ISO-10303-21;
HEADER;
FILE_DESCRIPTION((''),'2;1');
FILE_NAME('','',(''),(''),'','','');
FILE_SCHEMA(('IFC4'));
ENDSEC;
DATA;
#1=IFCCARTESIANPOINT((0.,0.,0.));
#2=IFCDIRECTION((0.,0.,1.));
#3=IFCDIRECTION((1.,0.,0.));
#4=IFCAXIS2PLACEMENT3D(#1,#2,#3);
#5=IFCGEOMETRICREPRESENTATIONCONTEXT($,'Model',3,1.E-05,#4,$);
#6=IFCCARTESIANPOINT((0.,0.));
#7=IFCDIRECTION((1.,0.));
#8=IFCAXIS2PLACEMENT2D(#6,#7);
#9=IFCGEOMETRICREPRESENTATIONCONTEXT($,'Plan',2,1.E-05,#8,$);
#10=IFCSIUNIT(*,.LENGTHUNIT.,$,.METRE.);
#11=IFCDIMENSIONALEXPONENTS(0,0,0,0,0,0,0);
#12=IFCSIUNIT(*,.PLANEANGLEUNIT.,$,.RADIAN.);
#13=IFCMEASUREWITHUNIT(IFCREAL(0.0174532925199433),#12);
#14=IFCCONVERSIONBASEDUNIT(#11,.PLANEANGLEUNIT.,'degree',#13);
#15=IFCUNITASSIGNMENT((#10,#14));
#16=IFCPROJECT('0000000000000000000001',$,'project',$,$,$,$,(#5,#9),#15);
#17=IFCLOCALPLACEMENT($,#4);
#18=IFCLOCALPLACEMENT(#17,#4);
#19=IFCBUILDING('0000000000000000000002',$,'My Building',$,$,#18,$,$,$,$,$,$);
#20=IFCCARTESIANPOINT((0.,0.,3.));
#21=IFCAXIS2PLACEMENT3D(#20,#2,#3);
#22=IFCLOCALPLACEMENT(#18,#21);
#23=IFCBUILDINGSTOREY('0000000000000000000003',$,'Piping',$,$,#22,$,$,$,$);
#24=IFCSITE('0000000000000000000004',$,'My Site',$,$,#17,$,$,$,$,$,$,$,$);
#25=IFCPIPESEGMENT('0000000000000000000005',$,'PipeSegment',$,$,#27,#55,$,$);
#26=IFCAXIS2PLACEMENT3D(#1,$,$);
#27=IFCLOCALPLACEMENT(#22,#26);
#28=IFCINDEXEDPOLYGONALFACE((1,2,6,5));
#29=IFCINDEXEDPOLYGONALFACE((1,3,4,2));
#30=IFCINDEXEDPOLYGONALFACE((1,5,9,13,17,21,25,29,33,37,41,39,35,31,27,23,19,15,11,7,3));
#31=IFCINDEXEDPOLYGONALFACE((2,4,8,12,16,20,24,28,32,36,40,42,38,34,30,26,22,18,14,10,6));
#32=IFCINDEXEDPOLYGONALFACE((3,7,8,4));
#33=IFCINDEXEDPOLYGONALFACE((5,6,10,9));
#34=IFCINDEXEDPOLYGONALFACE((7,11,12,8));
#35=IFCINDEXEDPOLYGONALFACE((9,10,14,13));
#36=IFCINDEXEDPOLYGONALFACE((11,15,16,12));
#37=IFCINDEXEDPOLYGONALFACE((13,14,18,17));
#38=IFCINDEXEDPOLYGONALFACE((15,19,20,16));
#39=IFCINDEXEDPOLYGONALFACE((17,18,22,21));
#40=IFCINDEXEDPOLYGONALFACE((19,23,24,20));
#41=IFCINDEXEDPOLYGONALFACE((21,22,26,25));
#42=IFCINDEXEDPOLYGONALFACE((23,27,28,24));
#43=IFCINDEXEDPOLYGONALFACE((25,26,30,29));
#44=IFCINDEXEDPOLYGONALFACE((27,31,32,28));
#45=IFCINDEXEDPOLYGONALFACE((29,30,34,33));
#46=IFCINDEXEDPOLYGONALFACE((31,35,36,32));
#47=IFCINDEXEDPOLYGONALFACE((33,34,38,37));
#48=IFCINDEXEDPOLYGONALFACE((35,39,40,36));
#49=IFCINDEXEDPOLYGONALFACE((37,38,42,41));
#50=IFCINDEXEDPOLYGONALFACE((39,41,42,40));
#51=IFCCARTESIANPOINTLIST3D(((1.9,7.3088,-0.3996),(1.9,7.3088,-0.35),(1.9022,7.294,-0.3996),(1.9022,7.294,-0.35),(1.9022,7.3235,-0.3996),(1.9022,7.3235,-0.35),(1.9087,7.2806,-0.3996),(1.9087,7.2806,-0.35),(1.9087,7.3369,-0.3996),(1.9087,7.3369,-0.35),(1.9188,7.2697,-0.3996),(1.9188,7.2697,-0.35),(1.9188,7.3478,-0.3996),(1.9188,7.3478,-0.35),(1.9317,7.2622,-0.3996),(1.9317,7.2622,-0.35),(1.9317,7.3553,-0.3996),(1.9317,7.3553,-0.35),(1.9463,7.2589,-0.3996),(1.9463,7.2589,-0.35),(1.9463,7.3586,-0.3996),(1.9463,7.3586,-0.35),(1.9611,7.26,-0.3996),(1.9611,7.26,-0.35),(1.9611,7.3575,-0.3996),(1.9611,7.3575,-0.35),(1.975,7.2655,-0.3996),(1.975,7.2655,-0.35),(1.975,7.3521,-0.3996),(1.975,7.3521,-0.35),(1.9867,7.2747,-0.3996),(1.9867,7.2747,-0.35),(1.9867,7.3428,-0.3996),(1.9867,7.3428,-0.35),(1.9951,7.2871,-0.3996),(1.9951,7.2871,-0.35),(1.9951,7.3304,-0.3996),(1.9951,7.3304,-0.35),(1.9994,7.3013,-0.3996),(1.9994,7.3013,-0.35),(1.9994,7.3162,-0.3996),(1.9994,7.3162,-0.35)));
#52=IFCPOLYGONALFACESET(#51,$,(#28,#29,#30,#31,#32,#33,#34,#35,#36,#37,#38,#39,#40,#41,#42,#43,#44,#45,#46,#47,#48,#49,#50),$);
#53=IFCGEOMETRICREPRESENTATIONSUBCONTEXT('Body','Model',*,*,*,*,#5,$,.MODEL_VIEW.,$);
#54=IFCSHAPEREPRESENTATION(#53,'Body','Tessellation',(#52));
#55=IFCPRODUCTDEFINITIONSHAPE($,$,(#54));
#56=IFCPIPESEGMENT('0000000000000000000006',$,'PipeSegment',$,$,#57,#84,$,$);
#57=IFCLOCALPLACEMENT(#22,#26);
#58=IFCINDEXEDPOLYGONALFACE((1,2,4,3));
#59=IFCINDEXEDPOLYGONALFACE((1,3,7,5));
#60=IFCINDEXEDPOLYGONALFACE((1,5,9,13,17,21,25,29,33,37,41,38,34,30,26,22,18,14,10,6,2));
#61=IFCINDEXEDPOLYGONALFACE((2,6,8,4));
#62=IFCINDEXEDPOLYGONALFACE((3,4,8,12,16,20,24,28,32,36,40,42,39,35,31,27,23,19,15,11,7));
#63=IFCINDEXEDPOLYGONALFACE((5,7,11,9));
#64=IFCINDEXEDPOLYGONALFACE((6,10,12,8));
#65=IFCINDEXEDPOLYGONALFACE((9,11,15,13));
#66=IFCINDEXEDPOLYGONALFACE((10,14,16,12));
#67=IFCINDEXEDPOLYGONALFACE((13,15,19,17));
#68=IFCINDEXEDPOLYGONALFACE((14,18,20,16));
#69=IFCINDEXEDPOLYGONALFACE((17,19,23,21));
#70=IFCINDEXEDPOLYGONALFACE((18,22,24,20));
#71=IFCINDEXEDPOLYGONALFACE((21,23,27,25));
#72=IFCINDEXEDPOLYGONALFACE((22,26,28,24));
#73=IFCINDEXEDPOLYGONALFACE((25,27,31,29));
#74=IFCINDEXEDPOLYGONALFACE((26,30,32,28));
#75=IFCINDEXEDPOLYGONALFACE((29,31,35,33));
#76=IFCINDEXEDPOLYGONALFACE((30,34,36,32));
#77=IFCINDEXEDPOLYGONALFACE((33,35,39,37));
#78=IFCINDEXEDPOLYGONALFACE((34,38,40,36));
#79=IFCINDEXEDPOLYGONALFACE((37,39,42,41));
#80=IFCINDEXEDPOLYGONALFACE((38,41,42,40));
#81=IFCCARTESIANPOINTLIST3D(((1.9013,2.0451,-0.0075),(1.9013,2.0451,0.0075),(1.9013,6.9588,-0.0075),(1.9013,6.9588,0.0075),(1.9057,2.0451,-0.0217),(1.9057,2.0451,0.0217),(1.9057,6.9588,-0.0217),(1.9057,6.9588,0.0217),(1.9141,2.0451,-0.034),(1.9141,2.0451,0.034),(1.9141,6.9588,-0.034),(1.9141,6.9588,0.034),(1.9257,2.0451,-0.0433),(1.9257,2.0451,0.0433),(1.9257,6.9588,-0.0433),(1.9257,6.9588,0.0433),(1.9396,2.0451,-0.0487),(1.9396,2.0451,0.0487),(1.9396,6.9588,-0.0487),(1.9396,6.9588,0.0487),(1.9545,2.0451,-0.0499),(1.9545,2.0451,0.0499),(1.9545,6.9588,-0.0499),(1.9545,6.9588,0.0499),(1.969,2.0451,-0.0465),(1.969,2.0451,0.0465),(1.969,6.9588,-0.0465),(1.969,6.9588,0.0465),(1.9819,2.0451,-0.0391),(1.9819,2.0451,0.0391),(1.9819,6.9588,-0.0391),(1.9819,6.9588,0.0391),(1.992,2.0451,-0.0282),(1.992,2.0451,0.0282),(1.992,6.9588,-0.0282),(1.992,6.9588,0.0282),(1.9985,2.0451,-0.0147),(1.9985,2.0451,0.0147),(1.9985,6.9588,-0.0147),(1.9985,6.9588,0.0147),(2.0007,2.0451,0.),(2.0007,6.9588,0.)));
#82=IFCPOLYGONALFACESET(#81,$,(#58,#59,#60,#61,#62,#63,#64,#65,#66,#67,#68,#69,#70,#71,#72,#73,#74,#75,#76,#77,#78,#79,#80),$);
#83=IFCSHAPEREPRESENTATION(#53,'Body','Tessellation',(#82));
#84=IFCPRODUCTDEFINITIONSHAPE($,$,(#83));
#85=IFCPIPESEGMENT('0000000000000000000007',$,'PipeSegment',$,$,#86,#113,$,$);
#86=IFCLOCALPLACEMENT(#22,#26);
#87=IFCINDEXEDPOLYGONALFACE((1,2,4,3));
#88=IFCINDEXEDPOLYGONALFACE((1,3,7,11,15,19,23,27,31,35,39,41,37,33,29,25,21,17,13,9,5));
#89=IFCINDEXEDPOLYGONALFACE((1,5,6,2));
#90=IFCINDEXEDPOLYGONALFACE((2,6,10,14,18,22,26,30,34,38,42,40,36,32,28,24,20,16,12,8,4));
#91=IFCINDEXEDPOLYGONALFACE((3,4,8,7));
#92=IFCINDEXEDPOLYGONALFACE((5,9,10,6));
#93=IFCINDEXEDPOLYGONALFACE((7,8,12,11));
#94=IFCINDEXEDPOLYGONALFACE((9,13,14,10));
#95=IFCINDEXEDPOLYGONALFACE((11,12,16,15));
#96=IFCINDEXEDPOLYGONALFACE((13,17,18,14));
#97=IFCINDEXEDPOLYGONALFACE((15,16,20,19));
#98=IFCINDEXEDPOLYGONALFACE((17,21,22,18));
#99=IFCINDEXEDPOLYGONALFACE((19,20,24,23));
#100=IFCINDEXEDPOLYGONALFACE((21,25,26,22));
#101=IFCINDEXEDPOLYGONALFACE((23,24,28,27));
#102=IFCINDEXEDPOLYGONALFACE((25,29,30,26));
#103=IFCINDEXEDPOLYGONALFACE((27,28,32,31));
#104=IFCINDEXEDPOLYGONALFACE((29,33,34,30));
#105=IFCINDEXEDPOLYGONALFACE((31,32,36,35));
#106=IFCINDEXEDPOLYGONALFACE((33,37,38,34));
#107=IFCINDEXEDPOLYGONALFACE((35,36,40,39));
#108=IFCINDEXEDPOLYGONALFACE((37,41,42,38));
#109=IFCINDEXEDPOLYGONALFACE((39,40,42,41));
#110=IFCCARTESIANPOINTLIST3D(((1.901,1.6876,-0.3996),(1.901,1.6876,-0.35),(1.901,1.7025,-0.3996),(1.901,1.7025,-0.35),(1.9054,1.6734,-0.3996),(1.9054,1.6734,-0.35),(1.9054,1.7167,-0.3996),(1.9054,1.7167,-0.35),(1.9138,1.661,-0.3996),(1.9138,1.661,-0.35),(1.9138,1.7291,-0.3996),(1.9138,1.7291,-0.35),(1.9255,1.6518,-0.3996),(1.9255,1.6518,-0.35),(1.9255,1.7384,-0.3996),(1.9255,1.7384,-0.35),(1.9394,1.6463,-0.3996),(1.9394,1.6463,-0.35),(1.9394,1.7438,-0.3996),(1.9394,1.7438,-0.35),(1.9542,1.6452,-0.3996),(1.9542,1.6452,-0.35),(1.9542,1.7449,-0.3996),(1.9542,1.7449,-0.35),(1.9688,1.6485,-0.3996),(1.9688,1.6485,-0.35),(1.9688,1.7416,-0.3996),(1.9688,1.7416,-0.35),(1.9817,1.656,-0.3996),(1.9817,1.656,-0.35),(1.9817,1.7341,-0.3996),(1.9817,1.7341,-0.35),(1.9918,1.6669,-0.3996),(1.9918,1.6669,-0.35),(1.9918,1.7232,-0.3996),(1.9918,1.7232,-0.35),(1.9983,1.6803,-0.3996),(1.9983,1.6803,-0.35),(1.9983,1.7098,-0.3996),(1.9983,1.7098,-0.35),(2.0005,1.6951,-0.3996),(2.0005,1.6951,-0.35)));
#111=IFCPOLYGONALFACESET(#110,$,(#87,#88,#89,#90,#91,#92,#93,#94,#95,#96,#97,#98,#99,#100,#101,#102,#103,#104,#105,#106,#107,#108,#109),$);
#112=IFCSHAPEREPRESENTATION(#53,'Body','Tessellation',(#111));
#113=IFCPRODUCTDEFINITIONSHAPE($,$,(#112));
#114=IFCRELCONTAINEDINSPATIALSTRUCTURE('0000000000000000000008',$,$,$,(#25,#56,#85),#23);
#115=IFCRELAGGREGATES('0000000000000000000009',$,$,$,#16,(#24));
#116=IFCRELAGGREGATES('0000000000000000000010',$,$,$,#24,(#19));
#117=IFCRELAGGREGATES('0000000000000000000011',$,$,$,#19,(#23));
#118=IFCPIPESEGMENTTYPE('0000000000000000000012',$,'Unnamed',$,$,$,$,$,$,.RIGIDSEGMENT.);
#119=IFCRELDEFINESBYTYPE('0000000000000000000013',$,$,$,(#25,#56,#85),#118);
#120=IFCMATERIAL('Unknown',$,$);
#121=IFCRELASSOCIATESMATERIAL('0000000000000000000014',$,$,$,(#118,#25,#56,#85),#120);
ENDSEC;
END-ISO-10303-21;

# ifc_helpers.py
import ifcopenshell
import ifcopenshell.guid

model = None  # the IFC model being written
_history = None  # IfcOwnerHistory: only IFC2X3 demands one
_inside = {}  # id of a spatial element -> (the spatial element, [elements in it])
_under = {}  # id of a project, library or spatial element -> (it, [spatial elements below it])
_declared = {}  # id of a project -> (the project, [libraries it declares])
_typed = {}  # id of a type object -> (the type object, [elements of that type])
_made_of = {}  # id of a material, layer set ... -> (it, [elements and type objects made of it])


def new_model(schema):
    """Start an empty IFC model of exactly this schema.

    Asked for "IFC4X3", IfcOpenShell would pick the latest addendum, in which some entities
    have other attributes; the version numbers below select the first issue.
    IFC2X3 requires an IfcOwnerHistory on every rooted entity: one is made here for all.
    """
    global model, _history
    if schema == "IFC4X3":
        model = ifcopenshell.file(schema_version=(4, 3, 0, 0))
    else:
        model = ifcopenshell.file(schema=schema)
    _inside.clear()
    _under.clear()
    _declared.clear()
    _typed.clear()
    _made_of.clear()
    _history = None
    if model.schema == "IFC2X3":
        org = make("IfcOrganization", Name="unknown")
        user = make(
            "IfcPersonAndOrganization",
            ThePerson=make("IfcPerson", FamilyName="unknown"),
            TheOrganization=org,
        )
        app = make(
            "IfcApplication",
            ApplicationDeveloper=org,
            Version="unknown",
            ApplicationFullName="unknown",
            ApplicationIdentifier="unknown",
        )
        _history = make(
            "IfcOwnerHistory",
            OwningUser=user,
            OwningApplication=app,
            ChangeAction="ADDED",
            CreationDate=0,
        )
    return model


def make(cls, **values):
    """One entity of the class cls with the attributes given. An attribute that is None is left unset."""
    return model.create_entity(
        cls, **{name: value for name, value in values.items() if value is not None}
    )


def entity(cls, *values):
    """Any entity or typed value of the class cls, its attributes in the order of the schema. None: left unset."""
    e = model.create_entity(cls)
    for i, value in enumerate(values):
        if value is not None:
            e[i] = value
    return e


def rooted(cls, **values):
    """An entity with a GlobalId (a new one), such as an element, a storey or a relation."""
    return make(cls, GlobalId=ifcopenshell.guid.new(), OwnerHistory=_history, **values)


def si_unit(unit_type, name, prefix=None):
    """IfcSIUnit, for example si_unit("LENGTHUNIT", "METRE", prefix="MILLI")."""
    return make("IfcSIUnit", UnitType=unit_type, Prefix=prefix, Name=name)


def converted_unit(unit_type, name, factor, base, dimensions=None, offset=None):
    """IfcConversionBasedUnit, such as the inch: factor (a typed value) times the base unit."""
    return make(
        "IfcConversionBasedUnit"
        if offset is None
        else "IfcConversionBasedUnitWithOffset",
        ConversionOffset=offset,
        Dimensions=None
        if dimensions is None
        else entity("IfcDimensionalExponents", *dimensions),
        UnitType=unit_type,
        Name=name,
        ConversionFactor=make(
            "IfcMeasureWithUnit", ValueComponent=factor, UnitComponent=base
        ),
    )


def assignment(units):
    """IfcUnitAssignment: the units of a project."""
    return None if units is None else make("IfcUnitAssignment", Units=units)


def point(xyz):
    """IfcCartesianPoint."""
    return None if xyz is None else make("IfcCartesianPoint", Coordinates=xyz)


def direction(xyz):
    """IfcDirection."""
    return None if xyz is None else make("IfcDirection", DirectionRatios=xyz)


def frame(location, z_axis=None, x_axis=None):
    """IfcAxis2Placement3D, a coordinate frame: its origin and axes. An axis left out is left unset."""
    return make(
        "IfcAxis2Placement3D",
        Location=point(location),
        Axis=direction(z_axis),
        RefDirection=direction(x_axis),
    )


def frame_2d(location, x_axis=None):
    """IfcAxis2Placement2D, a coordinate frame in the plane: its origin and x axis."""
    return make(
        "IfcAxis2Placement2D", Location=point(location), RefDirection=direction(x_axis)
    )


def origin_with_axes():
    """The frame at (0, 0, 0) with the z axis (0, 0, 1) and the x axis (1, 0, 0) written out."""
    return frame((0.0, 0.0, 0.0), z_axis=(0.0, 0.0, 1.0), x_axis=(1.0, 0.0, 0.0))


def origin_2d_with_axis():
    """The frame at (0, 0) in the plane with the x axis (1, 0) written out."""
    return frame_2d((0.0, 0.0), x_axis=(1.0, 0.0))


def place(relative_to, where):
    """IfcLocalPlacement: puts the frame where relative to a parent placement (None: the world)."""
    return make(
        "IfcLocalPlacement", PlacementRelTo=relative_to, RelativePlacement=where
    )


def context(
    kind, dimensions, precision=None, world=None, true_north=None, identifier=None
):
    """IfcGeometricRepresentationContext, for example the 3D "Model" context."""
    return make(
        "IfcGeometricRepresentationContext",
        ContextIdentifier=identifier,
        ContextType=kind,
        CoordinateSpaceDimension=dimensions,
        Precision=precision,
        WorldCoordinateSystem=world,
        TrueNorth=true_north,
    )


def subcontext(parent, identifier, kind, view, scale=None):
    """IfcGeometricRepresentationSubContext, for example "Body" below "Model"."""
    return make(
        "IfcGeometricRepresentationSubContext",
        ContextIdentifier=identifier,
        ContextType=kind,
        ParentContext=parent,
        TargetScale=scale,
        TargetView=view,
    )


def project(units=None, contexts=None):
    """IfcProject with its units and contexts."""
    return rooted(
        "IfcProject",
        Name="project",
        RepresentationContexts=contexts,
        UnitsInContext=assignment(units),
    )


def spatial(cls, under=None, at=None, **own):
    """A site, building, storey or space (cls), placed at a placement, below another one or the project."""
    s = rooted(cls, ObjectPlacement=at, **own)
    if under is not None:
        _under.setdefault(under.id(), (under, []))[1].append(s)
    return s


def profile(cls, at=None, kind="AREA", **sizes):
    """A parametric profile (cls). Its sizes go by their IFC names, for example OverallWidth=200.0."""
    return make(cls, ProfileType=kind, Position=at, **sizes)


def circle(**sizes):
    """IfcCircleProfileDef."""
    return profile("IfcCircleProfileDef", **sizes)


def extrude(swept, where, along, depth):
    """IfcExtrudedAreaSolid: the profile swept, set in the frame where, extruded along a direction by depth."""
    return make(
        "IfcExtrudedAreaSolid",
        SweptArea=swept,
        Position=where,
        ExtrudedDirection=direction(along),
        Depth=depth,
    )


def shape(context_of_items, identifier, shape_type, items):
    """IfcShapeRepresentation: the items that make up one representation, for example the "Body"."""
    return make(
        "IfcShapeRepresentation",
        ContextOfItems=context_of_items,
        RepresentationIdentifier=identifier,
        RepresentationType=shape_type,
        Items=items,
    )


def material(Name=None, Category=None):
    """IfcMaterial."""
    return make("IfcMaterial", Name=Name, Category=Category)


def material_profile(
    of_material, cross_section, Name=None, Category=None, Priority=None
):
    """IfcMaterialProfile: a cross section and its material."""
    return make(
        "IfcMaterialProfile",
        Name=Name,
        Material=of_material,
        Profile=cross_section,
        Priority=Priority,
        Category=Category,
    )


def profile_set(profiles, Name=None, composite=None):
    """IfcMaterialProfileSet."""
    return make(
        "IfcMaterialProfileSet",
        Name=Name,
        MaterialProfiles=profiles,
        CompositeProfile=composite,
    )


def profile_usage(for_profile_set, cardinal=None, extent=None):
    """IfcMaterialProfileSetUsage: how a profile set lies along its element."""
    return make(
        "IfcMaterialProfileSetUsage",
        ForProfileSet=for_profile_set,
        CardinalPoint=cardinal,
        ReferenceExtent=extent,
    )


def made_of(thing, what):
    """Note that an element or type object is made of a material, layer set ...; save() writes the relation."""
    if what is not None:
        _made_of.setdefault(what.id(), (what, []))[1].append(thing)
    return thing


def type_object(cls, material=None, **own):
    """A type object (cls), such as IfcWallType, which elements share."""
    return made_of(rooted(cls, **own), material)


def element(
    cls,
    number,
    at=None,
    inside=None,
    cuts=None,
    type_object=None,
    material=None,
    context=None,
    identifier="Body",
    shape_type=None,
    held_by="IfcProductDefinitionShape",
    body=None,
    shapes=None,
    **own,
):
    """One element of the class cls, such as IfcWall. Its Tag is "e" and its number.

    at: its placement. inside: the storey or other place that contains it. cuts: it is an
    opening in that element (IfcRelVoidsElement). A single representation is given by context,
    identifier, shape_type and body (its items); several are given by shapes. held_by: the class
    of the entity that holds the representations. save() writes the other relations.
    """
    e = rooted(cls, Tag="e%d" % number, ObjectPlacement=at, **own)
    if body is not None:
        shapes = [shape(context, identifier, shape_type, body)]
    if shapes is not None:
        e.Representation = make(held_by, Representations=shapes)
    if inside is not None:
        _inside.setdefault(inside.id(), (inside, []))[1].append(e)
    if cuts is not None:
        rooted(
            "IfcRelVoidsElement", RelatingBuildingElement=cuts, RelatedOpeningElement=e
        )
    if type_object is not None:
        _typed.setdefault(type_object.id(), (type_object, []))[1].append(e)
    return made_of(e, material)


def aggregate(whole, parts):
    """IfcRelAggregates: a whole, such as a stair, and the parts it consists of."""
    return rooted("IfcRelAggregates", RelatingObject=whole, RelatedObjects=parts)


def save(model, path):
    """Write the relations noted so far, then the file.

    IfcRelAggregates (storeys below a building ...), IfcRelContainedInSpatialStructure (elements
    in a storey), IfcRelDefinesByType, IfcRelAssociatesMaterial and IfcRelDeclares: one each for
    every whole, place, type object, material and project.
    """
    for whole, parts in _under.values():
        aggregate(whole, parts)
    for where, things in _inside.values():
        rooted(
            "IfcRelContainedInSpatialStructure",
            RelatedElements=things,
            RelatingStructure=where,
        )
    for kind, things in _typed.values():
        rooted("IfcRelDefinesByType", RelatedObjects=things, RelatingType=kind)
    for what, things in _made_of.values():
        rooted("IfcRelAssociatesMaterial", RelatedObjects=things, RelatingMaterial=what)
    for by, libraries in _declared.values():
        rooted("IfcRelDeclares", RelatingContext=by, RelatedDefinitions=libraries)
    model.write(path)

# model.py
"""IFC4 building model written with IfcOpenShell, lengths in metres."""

from ifc_helpers import new_model, entity, si_unit, converted_unit, frame, origin_with_axes, origin_2d_with_axis, place, context, subcontext, project, spatial, circle, extrude, material, material_profile, profile_set, profile_usage, type_object, element, save


model = new_model("IFC4")

# Units and contexts
model_context = context("Model", 3, precision=1e-05, world=origin_with_axes())
plan_context = context("Plan", 2, precision=1e-05, world=origin_2d_with_axis())
body_context = subcontext(model_context, "Body", "Model", "MODEL_VIEW")
ifc_project = project(units=[si_unit("LENGTHUNIT", "METRE"), converted_unit("PLANEANGLEUNIT", "degree", entity("IfcReal", 0.0174532925199433), si_unit("PLANEANGLEUNIT", "RADIAN"), dimensions=[0, 0, 0, 0, 0, 0, 0])], contexts=[model_context, plan_context])

# Site, building, storey
site_placement = place(None, origin_with_axes())
site = spatial("IfcSite", under=ifc_project, at=site_placement, Name="My Site")
building_placement = place(site_placement, origin_with_axes())
building = spatial("IfcBuilding", under=site, at=building_placement, Name="My Building")
storey_placement = place(building_placement, frame((0.0, 0.0, 3.0), z_axis=(0.0, 0.0, 1.0), x_axis=(1.0, 0.0, 0.0)))
storey = spatial("IfcBuildingStorey", under=building, at=storey_placement, Name="Piping")

# Pipe segments
ifc_material = material(Name="Unknown")
ifc_material_profile = material_profile(ifc_material, circle(Radius=0.05))
ifc_profile_set = profile_set([ifc_material_profile])
pipe_segment_type = type_object("IfcPipeSegmentType", Name="Unnamed", PredefinedType="RIGIDSEGMENT", material=ifc_profile_set)
ifc_profile_usage_1 = profile_usage(ifc_profile_set, cardinal=5)
pipe_segment_1_placement = place(storey_placement, frame((1.95, 7.3088, -0.35), z_axis=(0.0, 0.0, -1.0), x_axis=(-1.0, 0.0, 0.0)))
element("IfcPipeSegment", 1, at=pipe_segment_1_placement, inside=storey, type_object=pipe_segment_type, material=ifc_profile_usage_1, Name="PipeSegment", context=body_context, shape_type="SweptSolid", body=[
    extrude(circle(Radius=0.05), origin_with_axes(), (0.0, 0.0, 1.0), 0.0496),
])
ifc_profile_usage_2 = profile_usage(ifc_profile_set, cardinal=5)
pipe_segment_2_placement = place(storey_placement, frame((1.9507, 6.9588, 0.0), z_axis=(0.0, -1.0, 0.0), x_axis=(1.0, 0.0, 0.0)))
element("IfcPipeSegment", 2, at=pipe_segment_2_placement, inside=storey, type_object=pipe_segment_type, material=ifc_profile_usage_2, Name="PipeSegment", context=body_context, shape_type="SweptSolid", body=[
    extrude(circle(Radius=0.05), origin_with_axes(), (0.0, 0.0, 1.0), 4.9137),
])
ifc_profile_usage_3 = profile_usage(ifc_profile_set, cardinal=5)
pipe_segment_3_placement = place(storey_placement, frame((1.9505, 1.6951, -0.35), z_axis=(0.0, 0.0, -1.0), x_axis=(1.0, 0.0, 0.0)))
element("IfcPipeSegment", 3, at=pipe_segment_3_placement, inside=storey, type_object=pipe_segment_type, material=ifc_profile_usage_3, Name="PipeSegment", context=body_context, shape_type="SweptSolid", body=[
    extrude(circle(Radius=0.05), origin_with_axes(), (0.0, 0.0, 1.0), 0.0496),
])

save(model, "model.ifc")
